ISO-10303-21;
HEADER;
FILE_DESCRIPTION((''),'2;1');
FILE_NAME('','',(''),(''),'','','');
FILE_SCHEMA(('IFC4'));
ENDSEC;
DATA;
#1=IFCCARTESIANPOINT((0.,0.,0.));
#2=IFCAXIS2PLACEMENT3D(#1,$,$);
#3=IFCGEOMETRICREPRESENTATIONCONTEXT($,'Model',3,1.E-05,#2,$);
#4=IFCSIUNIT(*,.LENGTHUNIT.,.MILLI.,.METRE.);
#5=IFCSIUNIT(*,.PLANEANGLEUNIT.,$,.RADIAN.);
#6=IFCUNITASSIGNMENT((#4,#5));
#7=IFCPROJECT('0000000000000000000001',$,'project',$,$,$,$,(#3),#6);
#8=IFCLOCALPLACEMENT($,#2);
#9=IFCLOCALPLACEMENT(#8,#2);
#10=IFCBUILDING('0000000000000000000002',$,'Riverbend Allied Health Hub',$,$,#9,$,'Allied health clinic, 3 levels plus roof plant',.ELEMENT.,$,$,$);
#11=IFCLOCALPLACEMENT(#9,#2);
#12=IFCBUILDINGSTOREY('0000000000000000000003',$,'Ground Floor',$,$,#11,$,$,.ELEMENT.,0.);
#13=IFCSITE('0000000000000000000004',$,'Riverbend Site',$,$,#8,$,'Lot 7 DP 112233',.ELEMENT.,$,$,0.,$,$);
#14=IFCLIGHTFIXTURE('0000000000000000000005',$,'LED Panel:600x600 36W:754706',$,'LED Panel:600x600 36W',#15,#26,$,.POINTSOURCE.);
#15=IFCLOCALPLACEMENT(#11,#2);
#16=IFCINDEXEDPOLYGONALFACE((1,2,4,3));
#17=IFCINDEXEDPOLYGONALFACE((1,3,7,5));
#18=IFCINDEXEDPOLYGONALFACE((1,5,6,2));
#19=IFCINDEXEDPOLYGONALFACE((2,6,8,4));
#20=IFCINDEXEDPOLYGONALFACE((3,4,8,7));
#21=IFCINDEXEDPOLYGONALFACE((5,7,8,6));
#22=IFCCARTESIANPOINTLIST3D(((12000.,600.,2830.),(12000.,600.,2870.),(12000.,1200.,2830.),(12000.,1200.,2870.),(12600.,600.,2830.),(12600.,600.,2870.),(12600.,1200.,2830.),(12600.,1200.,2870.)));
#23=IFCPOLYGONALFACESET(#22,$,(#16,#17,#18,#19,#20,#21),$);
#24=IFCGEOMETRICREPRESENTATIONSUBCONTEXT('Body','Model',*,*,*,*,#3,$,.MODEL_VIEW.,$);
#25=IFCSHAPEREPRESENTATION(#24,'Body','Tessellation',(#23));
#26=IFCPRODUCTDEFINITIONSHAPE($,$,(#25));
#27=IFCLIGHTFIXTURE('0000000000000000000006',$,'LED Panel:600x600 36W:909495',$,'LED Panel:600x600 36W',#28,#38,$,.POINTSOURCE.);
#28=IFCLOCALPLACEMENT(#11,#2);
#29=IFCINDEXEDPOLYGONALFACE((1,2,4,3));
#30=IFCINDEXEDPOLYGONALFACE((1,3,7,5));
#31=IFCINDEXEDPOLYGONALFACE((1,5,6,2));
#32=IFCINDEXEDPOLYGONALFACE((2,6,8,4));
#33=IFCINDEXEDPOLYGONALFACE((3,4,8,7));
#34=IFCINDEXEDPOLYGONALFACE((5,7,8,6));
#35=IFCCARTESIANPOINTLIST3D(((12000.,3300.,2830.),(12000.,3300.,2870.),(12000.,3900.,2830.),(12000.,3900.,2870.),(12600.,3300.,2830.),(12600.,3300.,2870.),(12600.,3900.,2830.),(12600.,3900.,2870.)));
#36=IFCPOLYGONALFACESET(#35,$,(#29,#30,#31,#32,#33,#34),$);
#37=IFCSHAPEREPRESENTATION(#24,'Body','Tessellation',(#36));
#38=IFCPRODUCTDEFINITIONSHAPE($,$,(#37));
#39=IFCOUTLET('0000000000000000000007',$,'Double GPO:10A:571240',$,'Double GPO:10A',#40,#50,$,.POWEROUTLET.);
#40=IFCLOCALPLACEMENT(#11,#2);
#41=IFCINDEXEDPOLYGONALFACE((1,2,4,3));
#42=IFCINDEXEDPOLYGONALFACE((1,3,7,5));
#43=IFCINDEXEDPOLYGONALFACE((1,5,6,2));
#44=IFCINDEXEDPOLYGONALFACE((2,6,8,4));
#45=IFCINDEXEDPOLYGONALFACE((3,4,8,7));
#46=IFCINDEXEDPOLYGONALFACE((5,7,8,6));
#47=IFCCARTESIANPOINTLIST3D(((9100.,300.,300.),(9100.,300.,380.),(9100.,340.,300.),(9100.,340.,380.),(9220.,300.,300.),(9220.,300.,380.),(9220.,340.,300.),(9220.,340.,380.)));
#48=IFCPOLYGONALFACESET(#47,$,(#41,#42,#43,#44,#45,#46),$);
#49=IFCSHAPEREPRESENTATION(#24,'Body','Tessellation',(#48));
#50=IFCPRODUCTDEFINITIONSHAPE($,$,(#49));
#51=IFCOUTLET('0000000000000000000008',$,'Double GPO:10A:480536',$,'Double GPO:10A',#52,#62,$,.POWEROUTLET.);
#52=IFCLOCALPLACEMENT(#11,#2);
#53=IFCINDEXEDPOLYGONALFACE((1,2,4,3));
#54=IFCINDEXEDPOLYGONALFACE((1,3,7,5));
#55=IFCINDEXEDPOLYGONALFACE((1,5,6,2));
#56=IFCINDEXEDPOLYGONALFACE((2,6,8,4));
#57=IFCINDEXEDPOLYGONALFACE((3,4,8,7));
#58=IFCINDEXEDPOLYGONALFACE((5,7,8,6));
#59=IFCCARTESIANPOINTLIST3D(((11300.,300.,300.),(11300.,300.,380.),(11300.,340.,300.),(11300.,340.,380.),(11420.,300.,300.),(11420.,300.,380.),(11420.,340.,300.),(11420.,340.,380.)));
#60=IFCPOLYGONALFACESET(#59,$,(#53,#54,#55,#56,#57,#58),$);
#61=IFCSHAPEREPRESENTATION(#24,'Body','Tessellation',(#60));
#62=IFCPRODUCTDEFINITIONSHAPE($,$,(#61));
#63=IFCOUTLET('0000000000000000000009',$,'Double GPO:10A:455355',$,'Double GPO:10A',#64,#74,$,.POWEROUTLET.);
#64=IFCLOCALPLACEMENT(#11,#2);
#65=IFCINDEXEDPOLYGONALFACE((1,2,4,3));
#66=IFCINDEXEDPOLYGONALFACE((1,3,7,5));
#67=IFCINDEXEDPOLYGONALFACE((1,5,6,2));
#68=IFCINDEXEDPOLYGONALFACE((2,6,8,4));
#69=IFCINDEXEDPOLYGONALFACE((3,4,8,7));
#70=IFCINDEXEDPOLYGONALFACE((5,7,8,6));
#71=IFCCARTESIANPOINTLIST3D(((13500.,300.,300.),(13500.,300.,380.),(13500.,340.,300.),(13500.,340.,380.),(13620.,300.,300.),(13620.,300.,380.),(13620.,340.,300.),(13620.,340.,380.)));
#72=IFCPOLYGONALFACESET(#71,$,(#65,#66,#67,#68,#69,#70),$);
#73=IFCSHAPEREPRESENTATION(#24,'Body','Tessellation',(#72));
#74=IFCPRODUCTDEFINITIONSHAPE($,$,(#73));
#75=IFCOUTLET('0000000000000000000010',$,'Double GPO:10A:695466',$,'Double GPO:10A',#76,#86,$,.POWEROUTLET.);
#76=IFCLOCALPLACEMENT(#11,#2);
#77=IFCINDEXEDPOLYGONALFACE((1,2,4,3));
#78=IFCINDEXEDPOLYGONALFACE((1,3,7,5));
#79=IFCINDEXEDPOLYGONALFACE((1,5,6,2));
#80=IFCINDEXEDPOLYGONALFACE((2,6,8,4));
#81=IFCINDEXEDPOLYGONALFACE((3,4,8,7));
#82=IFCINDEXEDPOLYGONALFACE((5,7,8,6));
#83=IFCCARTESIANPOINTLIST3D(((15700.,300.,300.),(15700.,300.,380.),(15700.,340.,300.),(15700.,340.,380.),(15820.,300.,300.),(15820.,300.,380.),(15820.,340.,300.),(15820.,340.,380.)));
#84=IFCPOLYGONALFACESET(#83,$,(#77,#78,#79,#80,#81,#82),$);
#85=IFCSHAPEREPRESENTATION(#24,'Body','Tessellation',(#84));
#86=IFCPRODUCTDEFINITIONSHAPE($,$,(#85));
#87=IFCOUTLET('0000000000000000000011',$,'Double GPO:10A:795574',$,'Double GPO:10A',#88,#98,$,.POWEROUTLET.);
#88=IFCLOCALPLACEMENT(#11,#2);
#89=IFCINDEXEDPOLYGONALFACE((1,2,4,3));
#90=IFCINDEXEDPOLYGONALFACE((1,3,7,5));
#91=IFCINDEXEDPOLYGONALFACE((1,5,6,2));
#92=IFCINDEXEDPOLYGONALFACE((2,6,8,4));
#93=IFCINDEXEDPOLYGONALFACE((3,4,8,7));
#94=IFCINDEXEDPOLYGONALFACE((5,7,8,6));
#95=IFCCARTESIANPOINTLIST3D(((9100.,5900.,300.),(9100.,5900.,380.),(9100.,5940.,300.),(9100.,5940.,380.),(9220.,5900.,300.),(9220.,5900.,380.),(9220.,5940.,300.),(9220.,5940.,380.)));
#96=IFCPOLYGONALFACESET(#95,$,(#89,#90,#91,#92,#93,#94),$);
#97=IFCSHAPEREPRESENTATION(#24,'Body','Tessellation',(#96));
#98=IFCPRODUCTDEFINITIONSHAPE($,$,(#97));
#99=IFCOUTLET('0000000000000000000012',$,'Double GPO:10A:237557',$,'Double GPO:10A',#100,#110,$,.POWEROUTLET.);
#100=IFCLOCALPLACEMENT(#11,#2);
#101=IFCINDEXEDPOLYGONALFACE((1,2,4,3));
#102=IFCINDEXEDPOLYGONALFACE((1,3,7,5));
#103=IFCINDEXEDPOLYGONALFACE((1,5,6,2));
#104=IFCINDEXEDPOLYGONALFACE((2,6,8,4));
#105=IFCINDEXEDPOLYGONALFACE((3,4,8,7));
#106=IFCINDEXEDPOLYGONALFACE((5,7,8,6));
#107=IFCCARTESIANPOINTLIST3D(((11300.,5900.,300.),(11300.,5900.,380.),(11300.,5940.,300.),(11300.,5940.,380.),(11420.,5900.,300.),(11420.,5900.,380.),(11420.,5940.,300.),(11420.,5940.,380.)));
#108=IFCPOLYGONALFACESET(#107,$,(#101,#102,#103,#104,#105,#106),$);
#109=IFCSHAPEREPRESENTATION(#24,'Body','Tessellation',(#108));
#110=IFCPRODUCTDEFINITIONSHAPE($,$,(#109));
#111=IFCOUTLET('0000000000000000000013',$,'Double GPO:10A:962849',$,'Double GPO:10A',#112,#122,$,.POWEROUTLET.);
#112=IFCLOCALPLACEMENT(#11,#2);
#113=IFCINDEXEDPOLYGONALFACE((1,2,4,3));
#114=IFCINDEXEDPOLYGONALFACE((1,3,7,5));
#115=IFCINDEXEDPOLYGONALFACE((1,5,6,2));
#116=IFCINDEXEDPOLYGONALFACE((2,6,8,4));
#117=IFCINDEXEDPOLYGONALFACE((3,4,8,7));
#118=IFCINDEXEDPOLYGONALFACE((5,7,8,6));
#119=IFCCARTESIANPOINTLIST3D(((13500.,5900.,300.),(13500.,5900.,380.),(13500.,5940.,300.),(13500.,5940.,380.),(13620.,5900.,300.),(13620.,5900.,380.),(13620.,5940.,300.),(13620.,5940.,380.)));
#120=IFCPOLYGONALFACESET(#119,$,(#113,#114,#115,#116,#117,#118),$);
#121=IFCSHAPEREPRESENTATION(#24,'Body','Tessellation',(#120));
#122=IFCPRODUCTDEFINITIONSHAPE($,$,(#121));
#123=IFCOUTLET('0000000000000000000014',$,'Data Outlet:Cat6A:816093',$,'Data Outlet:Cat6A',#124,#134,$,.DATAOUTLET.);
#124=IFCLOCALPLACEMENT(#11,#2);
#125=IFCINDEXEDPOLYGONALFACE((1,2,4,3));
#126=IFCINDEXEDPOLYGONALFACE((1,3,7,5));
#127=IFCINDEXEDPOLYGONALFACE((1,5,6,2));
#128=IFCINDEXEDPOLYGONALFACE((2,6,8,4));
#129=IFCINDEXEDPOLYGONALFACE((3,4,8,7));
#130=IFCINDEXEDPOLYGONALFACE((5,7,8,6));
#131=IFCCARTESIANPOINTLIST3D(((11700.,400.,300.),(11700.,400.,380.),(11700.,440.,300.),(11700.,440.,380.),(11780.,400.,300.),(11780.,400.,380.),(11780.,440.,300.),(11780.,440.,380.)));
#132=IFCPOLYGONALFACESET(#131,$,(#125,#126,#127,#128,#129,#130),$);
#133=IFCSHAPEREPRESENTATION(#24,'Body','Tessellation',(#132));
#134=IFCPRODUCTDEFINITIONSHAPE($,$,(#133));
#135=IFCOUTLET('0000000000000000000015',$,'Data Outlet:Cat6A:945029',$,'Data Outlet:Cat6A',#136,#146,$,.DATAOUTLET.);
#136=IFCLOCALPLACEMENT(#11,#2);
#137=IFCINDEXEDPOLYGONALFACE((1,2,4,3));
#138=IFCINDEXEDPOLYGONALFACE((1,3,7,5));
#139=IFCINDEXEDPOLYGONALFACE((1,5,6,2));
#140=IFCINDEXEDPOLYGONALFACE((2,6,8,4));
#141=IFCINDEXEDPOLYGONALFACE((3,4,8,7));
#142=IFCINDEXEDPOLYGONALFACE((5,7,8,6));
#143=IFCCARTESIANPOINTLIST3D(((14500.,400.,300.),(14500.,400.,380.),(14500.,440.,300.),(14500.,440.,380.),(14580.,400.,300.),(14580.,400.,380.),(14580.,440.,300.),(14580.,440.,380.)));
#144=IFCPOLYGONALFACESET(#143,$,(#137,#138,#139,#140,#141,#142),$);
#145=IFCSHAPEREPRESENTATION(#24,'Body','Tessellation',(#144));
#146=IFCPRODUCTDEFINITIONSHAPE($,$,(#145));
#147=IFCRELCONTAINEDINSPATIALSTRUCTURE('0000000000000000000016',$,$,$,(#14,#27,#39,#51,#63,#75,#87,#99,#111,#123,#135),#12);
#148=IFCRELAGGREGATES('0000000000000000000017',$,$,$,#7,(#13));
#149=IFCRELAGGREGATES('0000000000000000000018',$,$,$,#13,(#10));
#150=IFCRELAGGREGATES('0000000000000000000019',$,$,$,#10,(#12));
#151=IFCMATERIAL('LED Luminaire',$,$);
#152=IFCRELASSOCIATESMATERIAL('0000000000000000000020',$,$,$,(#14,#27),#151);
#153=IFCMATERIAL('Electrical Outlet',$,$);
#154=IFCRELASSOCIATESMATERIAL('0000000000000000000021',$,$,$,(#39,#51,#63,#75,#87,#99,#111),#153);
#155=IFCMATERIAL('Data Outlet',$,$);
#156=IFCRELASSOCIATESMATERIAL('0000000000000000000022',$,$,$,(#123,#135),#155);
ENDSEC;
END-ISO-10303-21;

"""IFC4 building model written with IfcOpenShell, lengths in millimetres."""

from ifc_helpers import new_model, si_unit, frame, frame_2d, origin, place, context, subcontext, project, spatial, rectangle, extrude, material, element, save


model = new_model("IFC4")

# Units and contexts
model_context = context("Model", 3, precision=1e-05, world=origin())
body_context = subcontext(model_context, "Body", "Model", "MODEL_VIEW")
ifc_project = project(units=[si_unit("LENGTHUNIT", "METRE", prefix="MILLI"), si_unit("PLANEANGLEUNIT", "RADIAN")], contexts=[model_context])

# Site, building, storey
site_placement = place(None, origin())
site = spatial("IfcSite", under=ifc_project, at=site_placement, Name="Riverbend Site", LongName="Lot 7 DP 112233", CompositionType="ELEMENT", RefElevation=0.0)
building_placement = place(site_placement, origin())
building = spatial("IfcBuilding", under=site, at=building_placement, Name="Riverbend Allied Health Hub", LongName="Allied health clinic, 3 levels plus roof plant", CompositionType="ELEMENT")
storey_placement = place(building_placement, origin())
storey = spatial("IfcBuildingStorey", under=building, at=storey_placement, Name="Ground Floor", CompositionType="ELEMENT", Elevation=0.0)

# Light fixtures
ifc_material_1 = material(Name="LED Luminaire")
for number, where, name in (
    (1, (12000.0, 600.0, 2830.0), "LED Panel:600x600 36W:754706"),
    (2, (12000.0, 3300.0, 2830.0), "LED Panel:600x600 36W:909495"),
):
    element("IfcLightFixture", number, at=place(storey_placement, frame(where)), inside=storey, material=ifc_material_1, Name=name, ObjectType="LED Panel:600x600 36W", PredefinedType="POINTSOURCE", context=body_context, shape_type="SweptSolid", body=[
        extrude(rectangle(XDim=600.0, YDim=600.0, at=frame_2d((300.0, 300.0))), origin(), (0.0, 0.0, 1.0), 40.0),
    ])

# Outlets
ifc_material_2 = material(Name="Electrical Outlet")
for number, where, name in (
    (3, (9100.0, 300.0, 300.0), "Double GPO:10A:571240"),
    (4, (11300.0, 300.0, 300.0), "Double GPO:10A:480536"),
    (5, (13500.0, 300.0, 300.0), "Double GPO:10A:455355"),
    (6, (15700.0, 300.0, 300.0), "Double GPO:10A:695466"),
    (7, (9100.0, 5900.0, 300.0), "Double GPO:10A:795574"),
    (8, (11300.0, 5900.0, 300.0), "Double GPO:10A:237557"),
    (9, (13500.0, 5900.0, 300.0), "Double GPO:10A:962849"),
):
    element("IfcOutlet", number, at=place(storey_placement, frame(where)), inside=storey, material=ifc_material_2, Name=name, ObjectType="Double GPO:10A", PredefinedType="POWEROUTLET", context=body_context, shape_type="SweptSolid", body=[
        extrude(rectangle(XDim=120.0, YDim=40.0, at=frame_2d((60.0, 20.0))), origin(), (0.0, 0.0, 1.0), 80.0),
    ])
ifc_material_3 = material(Name="Data Outlet")
for number, where, name in (
    (10, (11700.0, 400.0, 300.0), "Data Outlet:Cat6A:816093"),
    (11, (14500.0, 400.0, 300.0), "Data Outlet:Cat6A:945029"),
):
    element("IfcOutlet", number, at=place(storey_placement, frame(where)), inside=storey, material=ifc_material_3, Name=name, ObjectType="Data Outlet:Cat6A", PredefinedType="DATAOUTLET", context=body_context, shape_type="SweptSolid", body=[
        extrude(rectangle(XDim=80.0, YDim=40.0, at=frame_2d((40.0, 20.0))), origin(), (0.0, 0.0, 1.0), 80.0),
    ])

save(model, "model.ifc")
